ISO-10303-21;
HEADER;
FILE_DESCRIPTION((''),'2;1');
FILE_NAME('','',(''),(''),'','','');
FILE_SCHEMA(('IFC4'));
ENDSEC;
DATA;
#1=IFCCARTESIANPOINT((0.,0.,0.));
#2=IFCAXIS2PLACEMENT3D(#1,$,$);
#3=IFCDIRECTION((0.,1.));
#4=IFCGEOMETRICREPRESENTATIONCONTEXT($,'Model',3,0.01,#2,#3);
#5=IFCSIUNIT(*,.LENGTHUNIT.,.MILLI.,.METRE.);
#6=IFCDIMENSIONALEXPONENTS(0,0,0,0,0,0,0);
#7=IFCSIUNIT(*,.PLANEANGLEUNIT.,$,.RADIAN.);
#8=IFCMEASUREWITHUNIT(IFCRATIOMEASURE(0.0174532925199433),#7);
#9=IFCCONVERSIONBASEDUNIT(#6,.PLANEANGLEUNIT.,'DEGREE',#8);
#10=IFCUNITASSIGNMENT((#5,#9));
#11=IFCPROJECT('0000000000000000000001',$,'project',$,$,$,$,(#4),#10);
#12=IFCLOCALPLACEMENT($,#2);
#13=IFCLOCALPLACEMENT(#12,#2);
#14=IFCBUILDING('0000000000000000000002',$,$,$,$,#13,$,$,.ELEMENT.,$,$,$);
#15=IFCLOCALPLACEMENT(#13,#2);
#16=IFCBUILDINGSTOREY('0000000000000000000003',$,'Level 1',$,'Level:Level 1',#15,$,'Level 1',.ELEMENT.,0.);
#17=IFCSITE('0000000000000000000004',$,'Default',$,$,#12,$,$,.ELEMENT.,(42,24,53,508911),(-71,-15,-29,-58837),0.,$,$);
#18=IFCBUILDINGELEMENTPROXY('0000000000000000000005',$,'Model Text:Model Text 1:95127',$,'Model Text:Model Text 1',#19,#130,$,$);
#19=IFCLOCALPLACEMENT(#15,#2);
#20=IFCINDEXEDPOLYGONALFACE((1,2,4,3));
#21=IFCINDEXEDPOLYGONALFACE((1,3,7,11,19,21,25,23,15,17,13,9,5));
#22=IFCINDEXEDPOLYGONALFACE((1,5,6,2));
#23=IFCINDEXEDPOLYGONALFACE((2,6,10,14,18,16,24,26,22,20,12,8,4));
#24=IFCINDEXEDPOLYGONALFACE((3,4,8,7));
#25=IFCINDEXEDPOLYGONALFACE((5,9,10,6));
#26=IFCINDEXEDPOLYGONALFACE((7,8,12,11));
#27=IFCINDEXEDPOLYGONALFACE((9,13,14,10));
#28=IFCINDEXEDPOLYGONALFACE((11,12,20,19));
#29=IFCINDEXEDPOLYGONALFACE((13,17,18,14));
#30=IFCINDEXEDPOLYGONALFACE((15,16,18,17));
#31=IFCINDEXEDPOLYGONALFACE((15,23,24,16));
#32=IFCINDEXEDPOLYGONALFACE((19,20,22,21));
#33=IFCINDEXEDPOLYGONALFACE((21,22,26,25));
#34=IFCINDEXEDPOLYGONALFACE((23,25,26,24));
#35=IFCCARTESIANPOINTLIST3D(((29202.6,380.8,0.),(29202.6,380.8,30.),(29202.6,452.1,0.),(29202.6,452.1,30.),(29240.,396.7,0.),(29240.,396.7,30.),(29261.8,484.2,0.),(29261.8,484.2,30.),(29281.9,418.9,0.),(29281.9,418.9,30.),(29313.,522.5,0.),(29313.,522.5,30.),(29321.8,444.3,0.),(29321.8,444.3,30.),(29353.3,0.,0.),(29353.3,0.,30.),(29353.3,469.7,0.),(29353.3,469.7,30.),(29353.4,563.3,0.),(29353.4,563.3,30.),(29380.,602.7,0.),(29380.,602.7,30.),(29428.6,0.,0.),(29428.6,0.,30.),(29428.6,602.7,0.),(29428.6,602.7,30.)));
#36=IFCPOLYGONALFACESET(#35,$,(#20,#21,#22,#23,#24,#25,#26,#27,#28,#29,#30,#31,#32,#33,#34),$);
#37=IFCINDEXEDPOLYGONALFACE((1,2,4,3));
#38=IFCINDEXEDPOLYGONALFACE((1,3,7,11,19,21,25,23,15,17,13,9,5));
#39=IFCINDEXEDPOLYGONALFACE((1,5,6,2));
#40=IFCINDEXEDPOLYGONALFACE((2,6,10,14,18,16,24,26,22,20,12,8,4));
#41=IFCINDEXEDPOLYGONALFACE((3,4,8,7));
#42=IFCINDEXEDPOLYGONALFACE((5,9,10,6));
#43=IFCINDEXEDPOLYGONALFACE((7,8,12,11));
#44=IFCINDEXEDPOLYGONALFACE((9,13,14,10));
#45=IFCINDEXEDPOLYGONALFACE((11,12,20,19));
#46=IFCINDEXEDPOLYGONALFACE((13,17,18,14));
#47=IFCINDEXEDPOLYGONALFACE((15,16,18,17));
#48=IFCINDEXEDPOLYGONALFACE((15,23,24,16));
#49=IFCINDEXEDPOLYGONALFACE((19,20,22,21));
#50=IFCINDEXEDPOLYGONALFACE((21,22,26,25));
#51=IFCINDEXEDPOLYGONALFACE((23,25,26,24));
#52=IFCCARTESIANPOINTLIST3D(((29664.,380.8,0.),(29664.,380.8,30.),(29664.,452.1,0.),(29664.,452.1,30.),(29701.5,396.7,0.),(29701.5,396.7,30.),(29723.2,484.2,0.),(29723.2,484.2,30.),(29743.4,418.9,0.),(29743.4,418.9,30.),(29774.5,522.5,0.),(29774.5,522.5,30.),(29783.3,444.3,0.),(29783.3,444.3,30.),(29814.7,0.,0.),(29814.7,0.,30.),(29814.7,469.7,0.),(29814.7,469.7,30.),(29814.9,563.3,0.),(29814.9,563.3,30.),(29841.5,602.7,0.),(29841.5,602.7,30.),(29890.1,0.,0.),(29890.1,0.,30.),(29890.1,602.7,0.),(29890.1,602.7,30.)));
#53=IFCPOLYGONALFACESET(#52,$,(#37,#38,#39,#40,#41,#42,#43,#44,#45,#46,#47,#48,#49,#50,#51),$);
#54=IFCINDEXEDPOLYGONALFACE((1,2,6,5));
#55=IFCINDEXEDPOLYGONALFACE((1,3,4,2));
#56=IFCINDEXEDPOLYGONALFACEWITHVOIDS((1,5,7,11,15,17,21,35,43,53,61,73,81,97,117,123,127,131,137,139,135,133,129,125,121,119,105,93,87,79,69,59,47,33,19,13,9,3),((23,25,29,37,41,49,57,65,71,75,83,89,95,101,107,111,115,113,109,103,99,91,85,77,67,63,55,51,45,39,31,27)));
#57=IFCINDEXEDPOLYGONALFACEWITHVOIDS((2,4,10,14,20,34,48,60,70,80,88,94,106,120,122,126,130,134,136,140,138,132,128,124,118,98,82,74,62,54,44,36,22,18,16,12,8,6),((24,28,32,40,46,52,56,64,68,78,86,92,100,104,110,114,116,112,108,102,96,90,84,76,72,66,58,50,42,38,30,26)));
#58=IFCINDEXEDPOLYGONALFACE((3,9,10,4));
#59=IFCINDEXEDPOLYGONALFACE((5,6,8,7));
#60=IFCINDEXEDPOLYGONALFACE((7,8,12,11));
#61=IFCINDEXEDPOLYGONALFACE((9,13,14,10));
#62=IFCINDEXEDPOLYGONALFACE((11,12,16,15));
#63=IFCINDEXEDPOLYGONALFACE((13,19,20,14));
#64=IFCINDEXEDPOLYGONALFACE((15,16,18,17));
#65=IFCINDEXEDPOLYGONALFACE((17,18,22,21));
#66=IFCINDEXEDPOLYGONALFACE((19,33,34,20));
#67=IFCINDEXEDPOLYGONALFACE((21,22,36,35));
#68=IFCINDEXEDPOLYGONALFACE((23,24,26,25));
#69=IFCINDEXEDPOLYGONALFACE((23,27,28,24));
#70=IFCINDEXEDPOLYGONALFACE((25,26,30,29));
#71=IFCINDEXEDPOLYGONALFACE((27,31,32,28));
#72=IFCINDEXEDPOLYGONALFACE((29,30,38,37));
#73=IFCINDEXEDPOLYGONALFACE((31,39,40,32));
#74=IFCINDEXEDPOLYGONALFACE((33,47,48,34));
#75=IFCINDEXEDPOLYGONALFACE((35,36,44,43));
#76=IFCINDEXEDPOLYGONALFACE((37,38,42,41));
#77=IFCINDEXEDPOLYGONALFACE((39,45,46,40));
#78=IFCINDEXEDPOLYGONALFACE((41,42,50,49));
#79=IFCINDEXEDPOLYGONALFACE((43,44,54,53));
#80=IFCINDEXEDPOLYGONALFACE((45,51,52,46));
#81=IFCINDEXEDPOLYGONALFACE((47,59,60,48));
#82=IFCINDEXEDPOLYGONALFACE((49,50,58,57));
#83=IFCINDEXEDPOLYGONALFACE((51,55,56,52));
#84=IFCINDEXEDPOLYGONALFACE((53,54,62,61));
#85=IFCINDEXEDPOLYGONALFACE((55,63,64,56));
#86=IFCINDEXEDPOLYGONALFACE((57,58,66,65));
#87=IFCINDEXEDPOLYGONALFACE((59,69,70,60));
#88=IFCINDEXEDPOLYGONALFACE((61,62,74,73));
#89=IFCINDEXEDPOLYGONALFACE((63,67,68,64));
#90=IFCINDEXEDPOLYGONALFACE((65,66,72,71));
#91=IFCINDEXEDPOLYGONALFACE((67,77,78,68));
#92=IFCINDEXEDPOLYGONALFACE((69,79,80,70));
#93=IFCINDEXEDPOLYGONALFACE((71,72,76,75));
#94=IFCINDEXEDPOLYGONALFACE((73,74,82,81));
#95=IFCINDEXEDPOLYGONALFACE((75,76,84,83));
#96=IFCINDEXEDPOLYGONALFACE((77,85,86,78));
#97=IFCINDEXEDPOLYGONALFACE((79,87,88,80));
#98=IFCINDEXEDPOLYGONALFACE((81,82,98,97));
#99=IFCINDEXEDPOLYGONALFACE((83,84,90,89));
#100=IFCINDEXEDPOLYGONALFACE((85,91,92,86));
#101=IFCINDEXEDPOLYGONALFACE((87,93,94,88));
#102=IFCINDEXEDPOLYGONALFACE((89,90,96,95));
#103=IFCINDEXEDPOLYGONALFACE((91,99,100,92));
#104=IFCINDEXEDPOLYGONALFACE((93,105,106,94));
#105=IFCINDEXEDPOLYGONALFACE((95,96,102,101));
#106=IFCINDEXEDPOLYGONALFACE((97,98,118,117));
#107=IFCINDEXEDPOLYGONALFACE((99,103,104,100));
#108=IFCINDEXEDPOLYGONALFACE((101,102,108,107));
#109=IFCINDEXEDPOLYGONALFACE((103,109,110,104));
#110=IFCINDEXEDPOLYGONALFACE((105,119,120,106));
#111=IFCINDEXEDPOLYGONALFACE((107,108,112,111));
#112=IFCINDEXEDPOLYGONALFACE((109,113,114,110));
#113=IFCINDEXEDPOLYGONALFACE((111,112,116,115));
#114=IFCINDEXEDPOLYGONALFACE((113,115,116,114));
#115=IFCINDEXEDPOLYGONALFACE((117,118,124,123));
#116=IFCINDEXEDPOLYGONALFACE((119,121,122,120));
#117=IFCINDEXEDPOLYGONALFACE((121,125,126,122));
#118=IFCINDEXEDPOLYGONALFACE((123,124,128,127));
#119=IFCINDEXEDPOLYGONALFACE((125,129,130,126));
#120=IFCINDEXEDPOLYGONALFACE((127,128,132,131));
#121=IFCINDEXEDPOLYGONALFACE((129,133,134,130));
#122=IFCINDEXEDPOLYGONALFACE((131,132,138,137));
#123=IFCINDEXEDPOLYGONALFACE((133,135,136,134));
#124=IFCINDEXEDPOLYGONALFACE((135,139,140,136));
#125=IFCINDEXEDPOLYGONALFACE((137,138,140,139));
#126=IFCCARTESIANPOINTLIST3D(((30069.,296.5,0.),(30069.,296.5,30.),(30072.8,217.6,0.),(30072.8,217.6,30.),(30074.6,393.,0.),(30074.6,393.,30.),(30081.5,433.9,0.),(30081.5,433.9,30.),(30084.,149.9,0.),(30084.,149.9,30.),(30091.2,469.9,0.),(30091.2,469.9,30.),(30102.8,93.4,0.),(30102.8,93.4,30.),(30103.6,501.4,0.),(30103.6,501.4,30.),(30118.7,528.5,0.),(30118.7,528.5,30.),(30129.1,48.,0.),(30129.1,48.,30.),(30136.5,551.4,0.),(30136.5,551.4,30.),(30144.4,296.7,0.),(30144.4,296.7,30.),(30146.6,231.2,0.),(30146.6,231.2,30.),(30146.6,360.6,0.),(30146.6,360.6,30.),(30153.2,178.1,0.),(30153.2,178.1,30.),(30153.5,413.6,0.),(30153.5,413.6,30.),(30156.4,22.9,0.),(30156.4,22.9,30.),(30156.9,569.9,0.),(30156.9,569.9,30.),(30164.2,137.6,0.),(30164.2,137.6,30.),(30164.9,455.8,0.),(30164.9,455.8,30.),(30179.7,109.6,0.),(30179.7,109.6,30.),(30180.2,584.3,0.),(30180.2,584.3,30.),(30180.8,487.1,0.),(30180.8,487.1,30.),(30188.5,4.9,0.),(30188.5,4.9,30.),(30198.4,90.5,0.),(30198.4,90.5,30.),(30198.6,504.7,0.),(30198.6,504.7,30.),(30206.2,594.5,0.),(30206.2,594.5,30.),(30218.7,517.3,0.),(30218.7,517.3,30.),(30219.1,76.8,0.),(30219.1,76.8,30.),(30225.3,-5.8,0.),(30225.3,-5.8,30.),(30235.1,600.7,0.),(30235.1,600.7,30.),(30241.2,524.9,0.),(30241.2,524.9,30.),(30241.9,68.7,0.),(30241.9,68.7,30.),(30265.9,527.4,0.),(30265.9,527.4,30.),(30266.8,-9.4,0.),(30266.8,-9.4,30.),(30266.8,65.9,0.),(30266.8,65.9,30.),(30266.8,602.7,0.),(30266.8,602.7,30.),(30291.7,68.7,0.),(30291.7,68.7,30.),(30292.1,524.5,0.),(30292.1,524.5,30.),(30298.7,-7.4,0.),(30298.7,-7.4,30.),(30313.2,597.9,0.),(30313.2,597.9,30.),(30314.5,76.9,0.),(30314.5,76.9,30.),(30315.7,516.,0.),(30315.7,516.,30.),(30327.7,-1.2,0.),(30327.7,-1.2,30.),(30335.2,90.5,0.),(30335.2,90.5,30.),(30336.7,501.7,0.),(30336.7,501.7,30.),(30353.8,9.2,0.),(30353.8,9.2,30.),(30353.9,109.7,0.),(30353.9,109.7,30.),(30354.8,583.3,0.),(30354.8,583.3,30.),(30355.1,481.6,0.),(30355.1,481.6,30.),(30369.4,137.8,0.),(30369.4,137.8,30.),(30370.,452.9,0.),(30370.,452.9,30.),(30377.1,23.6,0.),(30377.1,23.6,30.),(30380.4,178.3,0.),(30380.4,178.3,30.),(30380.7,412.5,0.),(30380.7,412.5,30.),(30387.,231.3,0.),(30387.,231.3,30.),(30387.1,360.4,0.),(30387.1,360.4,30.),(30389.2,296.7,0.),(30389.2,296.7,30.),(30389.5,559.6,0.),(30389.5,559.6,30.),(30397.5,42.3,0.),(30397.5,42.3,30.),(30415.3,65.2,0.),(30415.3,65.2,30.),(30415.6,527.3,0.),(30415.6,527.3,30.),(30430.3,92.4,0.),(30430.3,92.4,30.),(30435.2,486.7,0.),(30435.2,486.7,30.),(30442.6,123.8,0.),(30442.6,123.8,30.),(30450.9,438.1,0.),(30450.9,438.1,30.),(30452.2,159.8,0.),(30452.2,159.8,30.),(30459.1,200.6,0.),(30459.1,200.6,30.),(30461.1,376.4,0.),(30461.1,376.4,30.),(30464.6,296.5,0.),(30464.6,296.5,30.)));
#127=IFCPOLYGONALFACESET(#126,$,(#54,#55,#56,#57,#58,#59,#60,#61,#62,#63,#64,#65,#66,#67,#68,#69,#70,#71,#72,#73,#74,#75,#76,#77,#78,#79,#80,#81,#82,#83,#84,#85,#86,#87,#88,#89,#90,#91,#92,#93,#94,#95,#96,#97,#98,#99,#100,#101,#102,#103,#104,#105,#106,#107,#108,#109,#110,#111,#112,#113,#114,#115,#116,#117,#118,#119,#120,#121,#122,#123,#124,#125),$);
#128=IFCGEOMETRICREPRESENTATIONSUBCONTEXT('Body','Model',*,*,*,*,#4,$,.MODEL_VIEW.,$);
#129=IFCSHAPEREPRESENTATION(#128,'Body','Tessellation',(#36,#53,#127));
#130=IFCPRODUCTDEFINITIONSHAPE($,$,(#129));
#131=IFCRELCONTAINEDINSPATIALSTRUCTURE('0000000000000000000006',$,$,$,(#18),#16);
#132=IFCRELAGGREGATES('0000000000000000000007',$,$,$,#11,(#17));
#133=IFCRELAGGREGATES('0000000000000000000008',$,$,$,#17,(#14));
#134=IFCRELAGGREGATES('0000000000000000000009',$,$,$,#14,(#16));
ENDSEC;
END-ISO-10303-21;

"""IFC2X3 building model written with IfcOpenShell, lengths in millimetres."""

from ifc_helpers import new_model, entity, si_unit, converted_unit, direction, frame, origin, place, context, subcontext, project, spatial, polyline, outline, extrude, element, save


model = new_model("IFC2X3")

# Units and contexts
model_context = context("Model", 3, precision=0.01, world=origin(), true_north=direction((0.0, 1.0)))
body_context = subcontext(model_context, "Body", "Model", "MODEL_VIEW")
ifc_project = project(units=[si_unit("LENGTHUNIT", "METRE", prefix="MILLI"), converted_unit("PLANEANGLEUNIT", "DEGREE", entity("IfcRatioMeasure", 0.0174532925199433), si_unit("PLANEANGLEUNIT", "RADIAN"), dimensions=[0, 0, 0, 0, 0, 0, 0])], contexts=[model_context])

# Site, building, storey
site_placement = place(None, origin())
site = spatial("IfcSite", under=ifc_project, at=site_placement, Name="Default", CompositionType="ELEMENT", RefLatitude=(42, 24, 53, 508911), RefLongitude=(-71, -15, -29, -58837), RefElevation=0.0)
building_placement = place(site_placement, origin())
building = spatial("IfcBuilding", under=site, at=building_placement, CompositionType="ELEMENT")
storey_placement = place(building_placement, origin())
storey = spatial("IfcBuildingStorey", under=building, at=storey_placement, Name="Level 1", ObjectType="Level:Level 1", LongName="Level 1", CompositionType="ELEMENT", Elevation=0.0)

# Building element proxy
proxy_1_placement = place(storey_placement, origin())
element("IfcBuildingElementProxy", 1, at=proxy_1_placement, inside=storey, Name="Model Text:Model Text 1:95127", ObjectType="Model Text:Model Text 1", context=body_context, shape_type="SweptSolid", body=[
    extrude(outline(polyline([(-410.6, -111.6), (192.1, -111.6), (192.1, -63.1), (152.7, -36.4), (111.9, 4.0), (73.6, 55.2), (41.4, 114.4), (-29.8, 114.4), (-13.9, 77.0), (8.3, 35.1), (33.7, -4.8), (59.1, -36.3), (-410.6, -36.3), (-410.6, -111.6)])), frame((29317.0, 410.6, 0.0), z_axis=(0.0, 0.0, 1.0), x_axis=(0.0, 1.0, 0.0)), (0.0, 0.0, 1.0), 30.0),
    extrude(outline(polyline([(-410.6, -111.6), (192.1, -111.6), (192.1, -63.1), (152.7, -36.4), (111.9, 4.0), (73.6, 55.2), (41.4, 114.4), (-29.8, 114.4), (-13.9, 77.0), (8.3, 35.1), (33.7, -4.8), (59.1, -36.3), (-410.6, -36.3), (-410.6, -111.6)])), frame((29778.5, 410.6, 0.0), z_axis=(0.0, 0.0, 1.0), x_axis=(0.0, 1.0, 0.0)), (0.0, 0.0, 1.0), 30.0),
    extrude(outline(polyline([(-10.6, -198.7), (68.3, -198.7), (136.5, -190.7), (193.9, -174.7), (240.5, -150.6), (266.9, -124.4), (286.3, -93.2), (298.8, -57.0), (304.3, -15.7), (303.8, 16.2), (299.0, 45.5), (289.9, 72.1), (276.6, 96.0), (258.9, 117.3), (236.9, 136.2), (210.4, 152.5), (179.6, 166.3), (144.1, 177.6), (103.7, 186.3), (8.2, 196.4), (-71.8, 196.7), (-134.0, 189.4), (-183.3, 176.1), (-224.7, 158.4), (-258.2, 133.9), (-283.5, 100.3), (-300.1, 59.5), (-307.1, 13.4), (-306.6, -18.4), (-301.8, -47.5), (-292.8, -74.0), (-279.6, -97.9), (-262.0, -119.2), (-240.0, -138.1), (-213.6, -154.5), (-182.8, -168.4), (-147.3, -179.8), (-106.7, -188.6), (-10.6, -198.7)]), holes=[polyline([(-7.2, -123.5), (-71.0, -118.2), (-123.6, -108.8), (-165.2, -95.4), (-195.7, -78.0), (-212.4, -59.4), (-224.1, -38.7), (-230.6, -15.9), (-231.9, 8.9), (-227.8, 35.0), (-218.1, 58.1), (-202.8, 78.4), (-182.0, 95.8), (-152.6, 109.4), (-111.7, 118.1), (-59.4, 122.0), (4.4, 121.1), (69.6, 115.8), (122.2, 106.7), (162.2, 93.7), (189.5, 77.0), (207.7, 57.4), (220.4, 36.0), (227.5, 12.8), (229.1, -12.1), (225.2, -36.8), (215.9, -59.2), (201.3, -79.3), (181.4, -97.1), (152.6, -111.2), (111.6, -120.3), (58.3, -124.4), (-7.2, -123.5)])]), frame((30268.0, 295.3, 0.0), z_axis=(0.0, 0.0, 1.0), x_axis=(0.047515, -0.998871, 0.0)), (0.0, 0.0, 1.0), 30.0),
])

save(model, "model.ifc")
